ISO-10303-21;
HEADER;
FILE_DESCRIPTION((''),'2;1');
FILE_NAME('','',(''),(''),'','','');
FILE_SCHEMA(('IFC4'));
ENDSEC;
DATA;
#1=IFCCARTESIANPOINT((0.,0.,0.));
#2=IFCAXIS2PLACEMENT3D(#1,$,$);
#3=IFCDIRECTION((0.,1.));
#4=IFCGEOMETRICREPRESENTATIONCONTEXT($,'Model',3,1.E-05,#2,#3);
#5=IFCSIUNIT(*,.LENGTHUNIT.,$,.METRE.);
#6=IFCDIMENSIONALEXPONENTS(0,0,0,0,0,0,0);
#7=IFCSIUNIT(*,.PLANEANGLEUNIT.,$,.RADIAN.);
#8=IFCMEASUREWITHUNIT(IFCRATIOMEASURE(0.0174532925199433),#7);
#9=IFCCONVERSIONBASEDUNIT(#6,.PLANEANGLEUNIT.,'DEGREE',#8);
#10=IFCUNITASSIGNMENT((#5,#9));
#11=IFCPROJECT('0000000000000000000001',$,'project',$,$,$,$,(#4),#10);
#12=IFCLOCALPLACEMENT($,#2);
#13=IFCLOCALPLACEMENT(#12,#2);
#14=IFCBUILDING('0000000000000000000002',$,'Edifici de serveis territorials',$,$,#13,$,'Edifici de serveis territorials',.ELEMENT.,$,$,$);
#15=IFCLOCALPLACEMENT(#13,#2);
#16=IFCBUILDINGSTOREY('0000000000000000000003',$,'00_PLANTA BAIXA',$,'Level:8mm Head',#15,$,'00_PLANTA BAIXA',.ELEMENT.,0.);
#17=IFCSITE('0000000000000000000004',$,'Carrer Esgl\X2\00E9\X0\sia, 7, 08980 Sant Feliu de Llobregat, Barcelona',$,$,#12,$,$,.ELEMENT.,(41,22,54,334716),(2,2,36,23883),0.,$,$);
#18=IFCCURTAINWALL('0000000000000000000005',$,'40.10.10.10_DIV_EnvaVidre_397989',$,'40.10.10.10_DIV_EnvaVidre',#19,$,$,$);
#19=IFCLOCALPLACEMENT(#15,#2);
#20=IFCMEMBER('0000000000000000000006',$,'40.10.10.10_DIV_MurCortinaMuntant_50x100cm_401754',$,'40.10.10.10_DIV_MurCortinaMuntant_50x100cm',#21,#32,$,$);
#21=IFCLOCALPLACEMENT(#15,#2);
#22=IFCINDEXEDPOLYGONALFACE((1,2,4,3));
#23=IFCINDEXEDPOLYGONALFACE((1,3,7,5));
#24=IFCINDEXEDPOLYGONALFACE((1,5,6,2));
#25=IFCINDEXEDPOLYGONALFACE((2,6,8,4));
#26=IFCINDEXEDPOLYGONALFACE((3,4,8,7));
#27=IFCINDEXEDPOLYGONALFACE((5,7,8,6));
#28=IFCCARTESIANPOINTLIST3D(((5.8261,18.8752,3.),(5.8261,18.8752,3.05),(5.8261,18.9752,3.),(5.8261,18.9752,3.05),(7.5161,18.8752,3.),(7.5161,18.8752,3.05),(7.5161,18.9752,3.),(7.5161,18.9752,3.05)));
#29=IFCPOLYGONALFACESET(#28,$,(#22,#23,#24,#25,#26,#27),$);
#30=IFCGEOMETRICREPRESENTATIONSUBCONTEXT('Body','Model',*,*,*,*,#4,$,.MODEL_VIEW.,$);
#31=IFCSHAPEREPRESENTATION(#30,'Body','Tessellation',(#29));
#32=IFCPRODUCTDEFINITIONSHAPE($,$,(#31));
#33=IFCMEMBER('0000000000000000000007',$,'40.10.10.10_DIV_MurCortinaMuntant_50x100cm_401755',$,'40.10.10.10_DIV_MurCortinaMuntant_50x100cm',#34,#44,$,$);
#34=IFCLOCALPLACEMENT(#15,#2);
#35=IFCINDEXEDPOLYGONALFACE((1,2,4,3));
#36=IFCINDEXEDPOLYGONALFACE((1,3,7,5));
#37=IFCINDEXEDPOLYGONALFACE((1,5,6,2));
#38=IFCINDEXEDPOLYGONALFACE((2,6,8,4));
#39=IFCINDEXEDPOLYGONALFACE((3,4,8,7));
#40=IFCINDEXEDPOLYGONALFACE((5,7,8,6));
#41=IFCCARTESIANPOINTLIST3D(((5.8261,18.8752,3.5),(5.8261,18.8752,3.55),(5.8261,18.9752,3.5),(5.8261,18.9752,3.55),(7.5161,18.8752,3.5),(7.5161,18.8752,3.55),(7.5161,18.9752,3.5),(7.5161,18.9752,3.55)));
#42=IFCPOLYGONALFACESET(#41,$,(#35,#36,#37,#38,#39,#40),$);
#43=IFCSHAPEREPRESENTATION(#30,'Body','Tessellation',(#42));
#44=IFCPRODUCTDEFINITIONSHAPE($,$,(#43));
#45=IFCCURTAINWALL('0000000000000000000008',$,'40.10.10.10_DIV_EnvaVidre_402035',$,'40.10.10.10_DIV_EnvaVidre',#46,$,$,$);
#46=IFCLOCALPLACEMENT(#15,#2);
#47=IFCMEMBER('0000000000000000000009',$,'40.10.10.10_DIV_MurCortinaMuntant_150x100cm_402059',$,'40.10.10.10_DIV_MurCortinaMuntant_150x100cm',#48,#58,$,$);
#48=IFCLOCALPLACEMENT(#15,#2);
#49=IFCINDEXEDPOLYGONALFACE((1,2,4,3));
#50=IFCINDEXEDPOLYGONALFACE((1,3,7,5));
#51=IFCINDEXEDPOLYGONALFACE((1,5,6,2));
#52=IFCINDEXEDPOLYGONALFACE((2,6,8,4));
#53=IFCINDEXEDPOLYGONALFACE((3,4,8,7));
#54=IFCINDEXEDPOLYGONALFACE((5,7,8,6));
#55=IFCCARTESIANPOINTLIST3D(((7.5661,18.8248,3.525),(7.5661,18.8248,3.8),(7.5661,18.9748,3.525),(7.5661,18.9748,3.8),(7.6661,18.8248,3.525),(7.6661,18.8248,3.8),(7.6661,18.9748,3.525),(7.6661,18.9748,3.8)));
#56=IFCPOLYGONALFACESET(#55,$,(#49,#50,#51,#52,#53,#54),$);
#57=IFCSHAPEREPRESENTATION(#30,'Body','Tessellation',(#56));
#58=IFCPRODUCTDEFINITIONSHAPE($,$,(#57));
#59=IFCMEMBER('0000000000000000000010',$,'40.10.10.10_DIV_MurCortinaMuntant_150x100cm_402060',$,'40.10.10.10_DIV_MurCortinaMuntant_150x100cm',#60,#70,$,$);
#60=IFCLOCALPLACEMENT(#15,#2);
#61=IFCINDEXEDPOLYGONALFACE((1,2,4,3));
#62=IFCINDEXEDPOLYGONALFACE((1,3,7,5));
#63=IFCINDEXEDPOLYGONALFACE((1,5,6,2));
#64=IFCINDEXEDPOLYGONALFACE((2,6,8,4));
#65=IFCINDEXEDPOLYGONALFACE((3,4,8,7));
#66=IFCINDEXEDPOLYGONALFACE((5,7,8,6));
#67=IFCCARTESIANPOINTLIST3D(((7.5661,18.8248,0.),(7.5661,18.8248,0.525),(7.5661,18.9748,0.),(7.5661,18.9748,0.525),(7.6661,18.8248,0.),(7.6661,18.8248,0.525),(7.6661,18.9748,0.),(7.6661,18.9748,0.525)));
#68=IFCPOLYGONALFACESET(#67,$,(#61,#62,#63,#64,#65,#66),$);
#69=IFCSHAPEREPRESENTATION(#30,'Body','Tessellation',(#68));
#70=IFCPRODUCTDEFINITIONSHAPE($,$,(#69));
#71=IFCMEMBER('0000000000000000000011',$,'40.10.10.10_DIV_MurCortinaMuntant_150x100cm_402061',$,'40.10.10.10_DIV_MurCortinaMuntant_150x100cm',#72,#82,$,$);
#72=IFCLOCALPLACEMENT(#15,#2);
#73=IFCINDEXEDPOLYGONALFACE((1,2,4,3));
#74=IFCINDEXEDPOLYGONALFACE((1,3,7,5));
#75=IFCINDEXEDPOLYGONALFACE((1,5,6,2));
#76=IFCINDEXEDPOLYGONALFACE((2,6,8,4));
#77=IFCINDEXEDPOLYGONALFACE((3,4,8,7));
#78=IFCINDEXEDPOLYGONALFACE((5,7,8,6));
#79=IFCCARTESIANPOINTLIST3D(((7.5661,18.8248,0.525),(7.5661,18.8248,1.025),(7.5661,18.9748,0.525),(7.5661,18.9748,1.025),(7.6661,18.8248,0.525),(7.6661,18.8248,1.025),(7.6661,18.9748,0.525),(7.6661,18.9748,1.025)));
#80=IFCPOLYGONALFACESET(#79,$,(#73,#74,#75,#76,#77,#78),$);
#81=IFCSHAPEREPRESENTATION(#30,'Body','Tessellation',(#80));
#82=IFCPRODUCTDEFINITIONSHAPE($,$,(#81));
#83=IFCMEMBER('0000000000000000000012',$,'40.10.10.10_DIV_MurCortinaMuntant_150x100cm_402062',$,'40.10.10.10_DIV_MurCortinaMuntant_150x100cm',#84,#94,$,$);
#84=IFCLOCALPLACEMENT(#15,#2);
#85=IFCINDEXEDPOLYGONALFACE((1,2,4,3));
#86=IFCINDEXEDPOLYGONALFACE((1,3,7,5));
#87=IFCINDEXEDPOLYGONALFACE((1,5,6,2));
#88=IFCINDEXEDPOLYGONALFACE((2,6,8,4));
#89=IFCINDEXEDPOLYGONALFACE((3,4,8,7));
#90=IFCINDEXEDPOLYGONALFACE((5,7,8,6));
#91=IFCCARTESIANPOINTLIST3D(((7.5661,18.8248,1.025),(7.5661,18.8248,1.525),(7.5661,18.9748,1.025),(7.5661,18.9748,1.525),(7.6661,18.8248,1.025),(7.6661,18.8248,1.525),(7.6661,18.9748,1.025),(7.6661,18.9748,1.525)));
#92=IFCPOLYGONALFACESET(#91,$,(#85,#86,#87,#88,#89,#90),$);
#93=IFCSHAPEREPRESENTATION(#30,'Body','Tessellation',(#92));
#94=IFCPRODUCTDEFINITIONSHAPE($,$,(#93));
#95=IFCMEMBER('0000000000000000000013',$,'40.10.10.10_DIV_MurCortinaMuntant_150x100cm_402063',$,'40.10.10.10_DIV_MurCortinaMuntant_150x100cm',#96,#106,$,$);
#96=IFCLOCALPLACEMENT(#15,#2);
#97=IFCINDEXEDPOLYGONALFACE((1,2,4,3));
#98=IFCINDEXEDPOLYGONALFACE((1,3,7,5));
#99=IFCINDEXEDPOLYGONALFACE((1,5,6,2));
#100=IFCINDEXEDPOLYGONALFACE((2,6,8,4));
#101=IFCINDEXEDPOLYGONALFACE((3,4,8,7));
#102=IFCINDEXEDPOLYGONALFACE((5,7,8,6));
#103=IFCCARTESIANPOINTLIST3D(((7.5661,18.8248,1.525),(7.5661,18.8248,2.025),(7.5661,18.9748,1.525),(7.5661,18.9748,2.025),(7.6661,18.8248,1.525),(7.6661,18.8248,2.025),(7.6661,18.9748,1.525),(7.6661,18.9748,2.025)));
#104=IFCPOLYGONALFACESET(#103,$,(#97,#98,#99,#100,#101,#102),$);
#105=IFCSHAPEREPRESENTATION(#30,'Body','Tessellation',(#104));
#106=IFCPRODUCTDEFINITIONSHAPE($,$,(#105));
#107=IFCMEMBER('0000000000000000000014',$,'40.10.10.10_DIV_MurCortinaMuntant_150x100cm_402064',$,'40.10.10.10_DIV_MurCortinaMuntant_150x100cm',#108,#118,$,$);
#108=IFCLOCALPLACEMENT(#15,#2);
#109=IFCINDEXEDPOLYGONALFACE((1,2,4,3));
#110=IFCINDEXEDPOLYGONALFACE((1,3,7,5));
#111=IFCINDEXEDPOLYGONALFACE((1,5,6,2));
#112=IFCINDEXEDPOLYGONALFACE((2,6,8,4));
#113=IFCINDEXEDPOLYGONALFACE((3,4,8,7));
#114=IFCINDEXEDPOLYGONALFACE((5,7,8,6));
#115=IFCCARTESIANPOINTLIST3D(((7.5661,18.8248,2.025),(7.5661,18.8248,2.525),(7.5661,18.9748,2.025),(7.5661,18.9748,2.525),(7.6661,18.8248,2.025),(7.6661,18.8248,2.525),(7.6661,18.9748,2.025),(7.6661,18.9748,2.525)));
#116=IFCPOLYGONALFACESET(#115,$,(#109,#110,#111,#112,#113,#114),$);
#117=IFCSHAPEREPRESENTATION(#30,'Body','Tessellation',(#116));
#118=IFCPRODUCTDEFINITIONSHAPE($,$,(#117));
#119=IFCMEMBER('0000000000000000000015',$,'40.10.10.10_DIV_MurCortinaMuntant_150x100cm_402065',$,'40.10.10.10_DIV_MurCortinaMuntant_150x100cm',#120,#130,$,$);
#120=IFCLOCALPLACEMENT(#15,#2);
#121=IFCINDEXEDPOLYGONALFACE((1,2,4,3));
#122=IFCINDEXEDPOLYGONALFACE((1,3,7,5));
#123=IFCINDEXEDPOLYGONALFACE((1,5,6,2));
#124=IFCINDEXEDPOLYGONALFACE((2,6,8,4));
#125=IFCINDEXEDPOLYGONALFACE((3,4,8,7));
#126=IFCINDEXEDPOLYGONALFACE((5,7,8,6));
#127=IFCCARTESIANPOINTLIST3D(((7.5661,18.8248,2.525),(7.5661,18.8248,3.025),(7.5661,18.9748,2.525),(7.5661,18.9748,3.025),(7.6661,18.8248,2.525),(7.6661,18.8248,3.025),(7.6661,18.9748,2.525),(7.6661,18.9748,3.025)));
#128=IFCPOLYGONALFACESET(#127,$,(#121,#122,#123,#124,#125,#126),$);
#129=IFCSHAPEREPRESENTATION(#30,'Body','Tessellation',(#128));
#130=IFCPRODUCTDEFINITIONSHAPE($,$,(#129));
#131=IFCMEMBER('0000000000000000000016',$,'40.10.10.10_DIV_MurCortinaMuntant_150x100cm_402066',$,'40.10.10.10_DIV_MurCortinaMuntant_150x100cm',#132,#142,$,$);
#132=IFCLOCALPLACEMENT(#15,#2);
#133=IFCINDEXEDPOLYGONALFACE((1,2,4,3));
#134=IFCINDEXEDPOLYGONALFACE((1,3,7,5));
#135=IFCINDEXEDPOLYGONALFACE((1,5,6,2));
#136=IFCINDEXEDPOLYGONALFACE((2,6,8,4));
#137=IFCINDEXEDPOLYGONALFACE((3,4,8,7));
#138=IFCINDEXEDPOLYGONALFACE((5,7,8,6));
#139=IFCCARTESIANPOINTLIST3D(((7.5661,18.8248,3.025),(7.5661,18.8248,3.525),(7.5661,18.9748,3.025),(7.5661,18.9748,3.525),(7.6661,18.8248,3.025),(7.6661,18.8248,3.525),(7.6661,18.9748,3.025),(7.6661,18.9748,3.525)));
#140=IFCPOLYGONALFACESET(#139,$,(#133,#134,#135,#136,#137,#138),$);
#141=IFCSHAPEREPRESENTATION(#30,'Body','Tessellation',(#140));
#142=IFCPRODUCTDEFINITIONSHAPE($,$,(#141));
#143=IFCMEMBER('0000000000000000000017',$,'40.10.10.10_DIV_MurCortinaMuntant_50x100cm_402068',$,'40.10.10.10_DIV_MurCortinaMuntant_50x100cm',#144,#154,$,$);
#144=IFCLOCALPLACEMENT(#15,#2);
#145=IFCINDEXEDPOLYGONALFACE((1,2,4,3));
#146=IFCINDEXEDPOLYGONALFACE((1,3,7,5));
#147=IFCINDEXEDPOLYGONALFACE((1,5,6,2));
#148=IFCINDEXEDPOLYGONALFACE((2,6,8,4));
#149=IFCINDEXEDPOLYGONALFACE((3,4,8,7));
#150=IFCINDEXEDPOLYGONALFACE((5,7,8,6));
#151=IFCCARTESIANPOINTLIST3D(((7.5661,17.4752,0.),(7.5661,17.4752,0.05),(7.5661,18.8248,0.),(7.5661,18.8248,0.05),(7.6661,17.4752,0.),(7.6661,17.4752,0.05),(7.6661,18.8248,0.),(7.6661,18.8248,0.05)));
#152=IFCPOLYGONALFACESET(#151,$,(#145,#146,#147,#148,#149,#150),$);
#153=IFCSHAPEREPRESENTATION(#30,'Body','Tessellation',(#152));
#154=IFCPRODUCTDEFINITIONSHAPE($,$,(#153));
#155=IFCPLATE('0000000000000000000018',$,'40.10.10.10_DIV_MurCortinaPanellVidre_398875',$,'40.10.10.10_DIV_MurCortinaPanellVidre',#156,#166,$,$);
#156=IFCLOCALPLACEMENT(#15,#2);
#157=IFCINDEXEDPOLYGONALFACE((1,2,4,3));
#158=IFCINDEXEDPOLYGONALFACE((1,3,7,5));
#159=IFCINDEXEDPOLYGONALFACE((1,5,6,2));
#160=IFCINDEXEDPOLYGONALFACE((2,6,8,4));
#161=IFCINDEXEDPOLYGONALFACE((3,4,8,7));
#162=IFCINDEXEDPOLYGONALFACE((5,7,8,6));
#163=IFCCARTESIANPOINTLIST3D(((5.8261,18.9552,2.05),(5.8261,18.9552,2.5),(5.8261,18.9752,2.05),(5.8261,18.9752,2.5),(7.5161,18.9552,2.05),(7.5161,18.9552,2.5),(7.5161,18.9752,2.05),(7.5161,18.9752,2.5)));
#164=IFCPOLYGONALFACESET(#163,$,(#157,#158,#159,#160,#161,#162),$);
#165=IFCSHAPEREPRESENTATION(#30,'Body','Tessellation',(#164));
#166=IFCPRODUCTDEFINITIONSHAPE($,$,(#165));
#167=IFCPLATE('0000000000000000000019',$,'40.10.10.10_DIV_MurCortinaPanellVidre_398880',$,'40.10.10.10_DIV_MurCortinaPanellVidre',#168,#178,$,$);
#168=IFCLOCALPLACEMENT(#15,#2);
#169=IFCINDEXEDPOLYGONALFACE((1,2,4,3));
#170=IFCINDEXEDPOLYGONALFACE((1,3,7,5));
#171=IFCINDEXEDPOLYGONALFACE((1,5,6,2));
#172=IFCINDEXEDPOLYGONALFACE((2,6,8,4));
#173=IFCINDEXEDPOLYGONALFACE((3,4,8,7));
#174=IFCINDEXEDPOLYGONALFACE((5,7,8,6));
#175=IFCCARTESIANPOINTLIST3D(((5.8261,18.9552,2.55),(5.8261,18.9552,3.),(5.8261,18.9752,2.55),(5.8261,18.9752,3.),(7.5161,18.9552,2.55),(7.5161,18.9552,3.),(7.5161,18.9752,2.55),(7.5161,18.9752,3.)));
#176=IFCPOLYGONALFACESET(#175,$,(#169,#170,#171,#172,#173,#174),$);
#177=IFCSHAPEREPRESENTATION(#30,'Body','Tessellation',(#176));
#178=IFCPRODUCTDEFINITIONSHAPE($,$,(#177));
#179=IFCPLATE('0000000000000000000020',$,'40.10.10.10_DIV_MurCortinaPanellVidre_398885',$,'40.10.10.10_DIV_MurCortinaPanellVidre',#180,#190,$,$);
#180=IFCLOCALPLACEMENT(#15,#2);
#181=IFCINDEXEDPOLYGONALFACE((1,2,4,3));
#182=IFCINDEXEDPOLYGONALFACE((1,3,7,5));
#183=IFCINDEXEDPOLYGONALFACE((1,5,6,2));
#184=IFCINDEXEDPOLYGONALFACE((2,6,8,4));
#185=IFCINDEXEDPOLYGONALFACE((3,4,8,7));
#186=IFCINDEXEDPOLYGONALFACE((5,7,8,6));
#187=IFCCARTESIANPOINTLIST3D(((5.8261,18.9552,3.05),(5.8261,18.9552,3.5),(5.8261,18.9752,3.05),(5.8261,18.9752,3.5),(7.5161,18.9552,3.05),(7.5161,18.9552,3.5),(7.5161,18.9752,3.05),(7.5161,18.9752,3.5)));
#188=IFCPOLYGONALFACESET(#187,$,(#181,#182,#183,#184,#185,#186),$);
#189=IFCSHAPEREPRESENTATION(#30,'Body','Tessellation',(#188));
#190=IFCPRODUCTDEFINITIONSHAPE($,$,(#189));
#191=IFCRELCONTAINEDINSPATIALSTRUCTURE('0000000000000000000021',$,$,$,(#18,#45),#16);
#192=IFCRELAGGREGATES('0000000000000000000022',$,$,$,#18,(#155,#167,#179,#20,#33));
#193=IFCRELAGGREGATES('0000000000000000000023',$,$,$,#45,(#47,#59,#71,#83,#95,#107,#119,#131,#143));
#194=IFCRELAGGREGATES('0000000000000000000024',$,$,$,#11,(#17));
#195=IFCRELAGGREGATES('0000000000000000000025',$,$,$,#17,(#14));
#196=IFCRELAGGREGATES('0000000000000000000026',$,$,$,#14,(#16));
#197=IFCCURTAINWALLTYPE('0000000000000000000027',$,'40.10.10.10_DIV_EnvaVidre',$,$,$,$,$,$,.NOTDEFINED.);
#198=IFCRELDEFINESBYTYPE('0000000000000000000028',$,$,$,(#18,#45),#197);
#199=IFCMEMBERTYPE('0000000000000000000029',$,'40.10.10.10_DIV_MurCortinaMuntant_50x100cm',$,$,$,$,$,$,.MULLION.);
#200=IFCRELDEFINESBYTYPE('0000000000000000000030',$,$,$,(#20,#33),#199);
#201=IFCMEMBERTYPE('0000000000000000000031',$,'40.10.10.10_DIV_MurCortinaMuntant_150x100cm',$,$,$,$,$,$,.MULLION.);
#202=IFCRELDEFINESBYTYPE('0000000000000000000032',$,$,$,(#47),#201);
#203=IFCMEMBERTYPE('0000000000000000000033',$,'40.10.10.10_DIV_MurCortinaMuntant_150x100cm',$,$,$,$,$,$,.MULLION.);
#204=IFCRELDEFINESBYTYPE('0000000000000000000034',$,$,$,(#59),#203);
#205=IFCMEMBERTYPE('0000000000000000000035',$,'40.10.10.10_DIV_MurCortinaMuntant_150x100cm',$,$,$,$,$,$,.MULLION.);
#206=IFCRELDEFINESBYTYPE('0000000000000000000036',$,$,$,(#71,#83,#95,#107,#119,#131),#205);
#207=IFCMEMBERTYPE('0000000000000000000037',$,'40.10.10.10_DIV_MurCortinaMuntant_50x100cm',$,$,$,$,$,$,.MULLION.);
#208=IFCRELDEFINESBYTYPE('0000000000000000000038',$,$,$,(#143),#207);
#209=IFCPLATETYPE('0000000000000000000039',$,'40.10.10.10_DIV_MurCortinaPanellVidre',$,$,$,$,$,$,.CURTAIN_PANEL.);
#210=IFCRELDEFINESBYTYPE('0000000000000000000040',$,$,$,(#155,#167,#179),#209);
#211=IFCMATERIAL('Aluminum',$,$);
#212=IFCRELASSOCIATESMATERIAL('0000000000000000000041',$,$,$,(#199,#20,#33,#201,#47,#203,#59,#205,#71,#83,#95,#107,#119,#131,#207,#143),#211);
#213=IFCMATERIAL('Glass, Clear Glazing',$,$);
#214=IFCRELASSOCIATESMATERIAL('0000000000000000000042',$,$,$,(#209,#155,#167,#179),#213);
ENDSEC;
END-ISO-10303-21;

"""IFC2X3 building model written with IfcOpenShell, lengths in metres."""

from ifc_helpers import new_model, entity, si_unit, converted_unit, direction, frame, frame_2d, origin, origin_2d_with_axis, place, context, subcontext, project, spatial, rectangle, extrude, source, transform, mapped, material, type_object, type_shapes, element, aggregate, save


model = new_model("IFC2X3")

# Units and contexts
model_context = context("Model", 3, precision=1e-05, world=origin(), true_north=direction((0.0, 1.0)))
body_context = subcontext(model_context, "Body", "Model", "MODEL_VIEW")
ifc_project = project(units=[si_unit("LENGTHUNIT", "METRE"), converted_unit("PLANEANGLEUNIT", "DEGREE", entity("IfcRatioMeasure", 0.0174532925199433), si_unit("PLANEANGLEUNIT", "RADIAN"), dimensions=[0, 0, 0, 0, 0, 0, 0])], contexts=[model_context])

# Site, building, storey
site_placement = place(None, origin())
site = spatial("IfcSite", under=ifc_project, at=site_placement, Name="Carrer Església, 7, 08980 Sant Feliu de Llobregat, Barcelona", CompositionType="ELEMENT", RefLatitude=(41, 22, 54, 334716), RefLongitude=(2, 2, 36, 23883), RefElevation=0.0)
building_placement = place(site_placement, origin())
building = spatial("IfcBuilding", under=site, at=building_placement, Name="Edifici de serveis territorials", LongName="Edifici de serveis territorials", CompositionType="ELEMENT")
storey_placement = place(building_placement, origin())
storey = spatial("IfcBuildingStorey", under=building, at=storey_placement, Name="00_PLANTA BAIXA", ObjectType="Level:8mm Head", LongName="00_PLANTA BAIXA", CompositionType="ELEMENT", Elevation=0.0)

# Curtain walls, members
curtain_wall_type = type_object("IfcCurtainWallType", Name="40.10.10.10_DIV_EnvaVidre", PredefinedType="NOTDEFINED")
curtain_wall_1_placement = place(storey_placement, origin())
curtain_wall_1 = element("IfcCurtainWall", 1, at=curtain_wall_1_placement, inside=storey, type_object=curtain_wall_type, Name="40.10.10.10_DIV_EnvaVidre_397989", ObjectType="40.10.10.10_DIV_EnvaVidre")
ifc_material_1 = material(Name="Aluminum")
member_type_1 = type_object("IfcMemberType", Name="40.10.10.10_DIV_MurCortinaMuntant_50x100cm", PredefinedType="MULLION", material=ifc_material_1)
shared_shape_1 = source(origin(), body_context, "Body", "SweptSolid", [
    extrude(rectangle(XDim=0.1, YDim=0.05, at=origin_2d_with_axis()), frame((0.0, 0.0, -1.69), z_axis=(0.0, 0.0, 1.0), x_axis=(0.0, -1.0, 0.0)), (0.0, 0.0, 1.0), 1.69),
])
type_shapes(member_type_1, [shared_shape_1])
member_1_placement = place(storey_placement, frame((7.5161, 18.9252, 3.025), z_axis=(1.0, 0.0, 0.0), x_axis=(0.0, 0.0, 1.0)))
member_1 = element("IfcMember", 2, at=member_1_placement, type_object=member_type_1, material=ifc_material_1, Name="40.10.10.10_DIV_MurCortinaMuntant_50x100cm_401754", ObjectType="40.10.10.10_DIV_MurCortinaMuntant_50x100cm", context=body_context, shape_type="MappedRepresentation", body=[
    mapped(shared_shape_1, transform((0.0, 0.0, 0.0), scale=1.0)),
])
member_2_placement = place(storey_placement, frame((7.5161, 18.9252, 3.525), z_axis=(1.0, 0.0, 0.0), x_axis=(0.0, 0.0, 1.0)))
member_2 = element("IfcMember", 3, at=member_2_placement, type_object=member_type_1, material=ifc_material_1, Name="40.10.10.10_DIV_MurCortinaMuntant_50x100cm_401755", ObjectType="40.10.10.10_DIV_MurCortinaMuntant_50x100cm", context=body_context, shape_type="MappedRepresentation", body=[
    mapped(shared_shape_1, transform((0.0, 0.0, 0.0), scale=1.0)),
])
curtain_wall_2_placement = place(storey_placement, origin())
curtain_wall_2 = element("IfcCurtainWall", 4, at=curtain_wall_2_placement, inside=storey, type_object=curtain_wall_type, Name="40.10.10.10_DIV_EnvaVidre_402035", ObjectType="40.10.10.10_DIV_EnvaVidre")
member_type_2 = type_object("IfcMemberType", Name="40.10.10.10_DIV_MurCortinaMuntant_150x100cm", PredefinedType="MULLION", material=ifc_material_1)
shared_shape_2 = source(origin(), body_context, "Body", "SweptSolid", [
    extrude(rectangle(XDim=0.1, YDim=0.15, at=origin_2d_with_axis()), frame((-0.075, 0.0, -0.275), z_axis=(0.0, 0.0, 1.0), x_axis=(0.0, -1.0, 0.0)), (0.0, 0.0, 1.0), 0.275),
])
type_shapes(member_type_2, [shared_shape_2])
member_3_placement = place(storey_placement, frame((7.6161, 18.9748, 3.8), z_axis=(0.0, 0.0, 1.0), x_axis=(0.0, 1.0, 0.0)))
member_3 = element("IfcMember", 5, at=member_3_placement, type_object=member_type_2, material=ifc_material_1, Name="40.10.10.10_DIV_MurCortinaMuntant_150x100cm_402059", ObjectType="40.10.10.10_DIV_MurCortinaMuntant_150x100cm", context=body_context, shape_type="MappedRepresentation", body=[
    mapped(shared_shape_2, transform((0.0, 0.0, 0.0), scale=1.0)),
])
member_type_3 = type_object("IfcMemberType", Name="40.10.10.10_DIV_MurCortinaMuntant_150x100cm", PredefinedType="MULLION", material=ifc_material_1)
shared_shape_3 = source(origin(), body_context, "Body", "SweptSolid", [
    extrude(rectangle(XDim=0.1, YDim=0.15, at=origin_2d_with_axis()), frame((-0.075, 0.0, -0.525), z_axis=(0.0, 0.0, 1.0), x_axis=(0.0, -1.0, 0.0)), (0.0, 0.0, 1.0), 0.525),
])
type_shapes(member_type_3, [shared_shape_3])
member_4_placement = place(storey_placement, frame((7.6161, 18.9748, 0.525), z_axis=(0.0, 0.0, 1.0), x_axis=(0.0, 1.0, 0.0)))
member_4 = element("IfcMember", 6, at=member_4_placement, type_object=member_type_3, material=ifc_material_1, Name="40.10.10.10_DIV_MurCortinaMuntant_150x100cm_402060", ObjectType="40.10.10.10_DIV_MurCortinaMuntant_150x100cm", context=body_context, shape_type="MappedRepresentation", body=[
    mapped(shared_shape_3, transform((0.0, 0.0, 0.0), scale=1.0)),
])
member_type_4 = type_object("IfcMemberType", Name="40.10.10.10_DIV_MurCortinaMuntant_150x100cm", PredefinedType="MULLION", material=ifc_material_1)
shared_shape_4 = source(origin(), body_context, "Body", "SweptSolid", [
    extrude(rectangle(XDim=0.1, YDim=0.15, at=origin_2d_with_axis()), frame((-0.075, 0.0, -0.5), z_axis=(0.0, 0.0, 1.0), x_axis=(0.0, -1.0, 0.0)), (0.0, 0.0, 1.0), 0.5),
])
type_shapes(member_type_4, [shared_shape_4])
member_5_placement = place(storey_placement, frame((7.6161, 18.9748, 1.025), z_axis=(0.0, 0.0, 1.0), x_axis=(0.0, 1.0, 0.0)))
member_5 = element("IfcMember", 7, at=member_5_placement, type_object=member_type_4, material=ifc_material_1, Name="40.10.10.10_DIV_MurCortinaMuntant_150x100cm_402061", ObjectType="40.10.10.10_DIV_MurCortinaMuntant_150x100cm", context=body_context, shape_type="MappedRepresentation", body=[
    mapped(shared_shape_4, transform((0.0, 0.0, 0.0), scale=1.0)),
])
member_6_placement = place(storey_placement, frame((7.6161, 18.9748, 1.525), z_axis=(0.0, 0.0, 1.0), x_axis=(0.0, 1.0, 0.0)))
member_6 = element("IfcMember", 8, at=member_6_placement, type_object=member_type_4, material=ifc_material_1, Name="40.10.10.10_DIV_MurCortinaMuntant_150x100cm_402062", ObjectType="40.10.10.10_DIV_MurCortinaMuntant_150x100cm", context=body_context, shape_type="MappedRepresentation", body=[
    mapped(shared_shape_4, transform((0.0, 0.0, 0.0), scale=1.0)),
])
member_7_placement = place(storey_placement, frame((7.6161, 18.9748, 2.025), z_axis=(0.0, 0.0, 1.0), x_axis=(0.0, 1.0, 0.0)))
member_7 = element("IfcMember", 9, at=member_7_placement, type_object=member_type_4, material=ifc_material_1, Name="40.10.10.10_DIV_MurCortinaMuntant_150x100cm_402063", ObjectType="40.10.10.10_DIV_MurCortinaMuntant_150x100cm", context=body_context, shape_type="MappedRepresentation", body=[
    mapped(shared_shape_4, transform((0.0, 0.0, 0.0), scale=1.0)),
])
member_8_placement = place(storey_placement, frame((7.6161, 18.9748, 2.525), z_axis=(0.0, 0.0, 1.0), x_axis=(0.0, 1.0, 0.0)))
member_8 = element("IfcMember", 10, at=member_8_placement, type_object=member_type_4, material=ifc_material_1, Name="40.10.10.10_DIV_MurCortinaMuntant_150x100cm_402064", ObjectType="40.10.10.10_DIV_MurCortinaMuntant_150x100cm", context=body_context, shape_type="MappedRepresentation", body=[
    mapped(shared_shape_4, transform((0.0, 0.0, 0.0), scale=1.0)),
])
member_9_placement = place(storey_placement, frame((7.6161, 18.9748, 3.025), z_axis=(0.0, 0.0, 1.0), x_axis=(0.0, 1.0, 0.0)))
member_9 = element("IfcMember", 11, at=member_9_placement, type_object=member_type_4, material=ifc_material_1, Name="40.10.10.10_DIV_MurCortinaMuntant_150x100cm_402065", ObjectType="40.10.10.10_DIV_MurCortinaMuntant_150x100cm", context=body_context, shape_type="MappedRepresentation", body=[
    mapped(shared_shape_4, transform((0.0, 0.0, 0.0), scale=1.0)),
])
member_10_placement = place(storey_placement, frame((7.6161, 18.9748, 3.525), z_axis=(0.0, 0.0, 1.0), x_axis=(0.0, 1.0, 0.0)))
member_10 = element("IfcMember", 12, at=member_10_placement, type_object=member_type_4, material=ifc_material_1, Name="40.10.10.10_DIV_MurCortinaMuntant_150x100cm_402066", ObjectType="40.10.10.10_DIV_MurCortinaMuntant_150x100cm", context=body_context, shape_type="MappedRepresentation", body=[
    mapped(shared_shape_4, transform((0.0, 0.0, 0.0), scale=1.0)),
])
member_type_5 = type_object("IfcMemberType", Name="40.10.10.10_DIV_MurCortinaMuntant_50x100cm", PredefinedType="MULLION", material=ifc_material_1)
shared_shape_5 = source(origin(), body_context, "Body", "SweptSolid", [
    extrude(rectangle(XDim=0.1, YDim=0.05, at=origin_2d_with_axis()), frame((-0.025, 0.0, -1.3496), z_axis=(0.0, 0.0, 1.0), x_axis=(0.0, -1.0, 0.0)), (0.0, 0.0, 1.0), 1.3496),
])
type_shapes(member_type_5, [shared_shape_5])
member_11_placement = place(storey_placement, frame((7.6161, 18.8248, 0.0), z_axis=(0.0, 1.0, 0.0), x_axis=(0.0, 0.0, -1.0)))
member_11 = element("IfcMember", 13, at=member_11_placement, type_object=member_type_5, material=ifc_material_1, Name="40.10.10.10_DIV_MurCortinaMuntant_50x100cm_402068", ObjectType="40.10.10.10_DIV_MurCortinaMuntant_50x100cm", context=body_context, shape_type="MappedRepresentation", body=[
    mapped(shared_shape_5, transform((0.0, 0.0, 0.0), scale=1.0)),
])

# Plates
ifc_material_2 = material(Name="Glass, Clear Glazing")
plate_type_1 = type_object("IfcPlateType", Name="40.10.10.10_DIV_MurCortinaPanellVidre", PredefinedType="CURTAIN_PANEL", material=ifc_material_2)
shared_shape_6 = source(origin(), body_context, "Body", "SweptSolid", [
    extrude(rectangle(XDim=0.02, YDim=1.69, at=frame_2d((0.0, 0.0), x_axis=(1.0, 0.0))), frame((0.845, 0.01, 0.0), z_axis=(0.0, 0.0, 1.0), x_axis=(0.0, 1.0, 0.0)), (0.0, 0.0, 1.0), 0.45),
])
type_shapes(plate_type_1, [shared_shape_6])
plate_1_placement = place(curtain_wall_1_placement, frame((5.8261, 18.9552, 2.05)))
plate_1 = element("IfcPlate", 14, at=plate_1_placement, type_object=plate_type_1, material=ifc_material_2, Name="40.10.10.10_DIV_MurCortinaPanellVidre_398875", ObjectType="40.10.10.10_DIV_MurCortinaPanellVidre", context=body_context, shape_type="MappedRepresentation", body=[
    mapped(shared_shape_6, transform((0.0, 0.0, 0.0), scale=1.0)),
])
plate_2_placement = place(curtain_wall_1_placement, frame((5.8261, 18.9552, 2.55)))
plate_2 = element("IfcPlate", 15, at=plate_2_placement, type_object=plate_type_1, material=ifc_material_2, Name="40.10.10.10_DIV_MurCortinaPanellVidre_398880", ObjectType="40.10.10.10_DIV_MurCortinaPanellVidre", context=body_context, shape_type="MappedRepresentation", body=[
    mapped(shared_shape_6, transform((0.0, 0.0, 0.0), scale=1.0)),
])
plate_3_placement = place(curtain_wall_1_placement, frame((5.8261, 18.9552, 3.05)))
plate_3 = element("IfcPlate", 16, at=plate_3_placement, type_object=plate_type_1, material=ifc_material_2, Name="40.10.10.10_DIV_MurCortinaPanellVidre_398885", ObjectType="40.10.10.10_DIV_MurCortinaPanellVidre", context=body_context, shape_type="MappedRepresentation", body=[
    mapped(shared_shape_6, transform((0.0, 0.0, 0.0), scale=1.0)),
])
aggregate(curtain_wall_1, [plate_1, plate_2, plate_3, member_1, member_2])
aggregate(curtain_wall_2, [member_3, member_4, member_5, member_6, member_7, member_8, member_9, member_10, member_11])

save(model, "model.ifc")
